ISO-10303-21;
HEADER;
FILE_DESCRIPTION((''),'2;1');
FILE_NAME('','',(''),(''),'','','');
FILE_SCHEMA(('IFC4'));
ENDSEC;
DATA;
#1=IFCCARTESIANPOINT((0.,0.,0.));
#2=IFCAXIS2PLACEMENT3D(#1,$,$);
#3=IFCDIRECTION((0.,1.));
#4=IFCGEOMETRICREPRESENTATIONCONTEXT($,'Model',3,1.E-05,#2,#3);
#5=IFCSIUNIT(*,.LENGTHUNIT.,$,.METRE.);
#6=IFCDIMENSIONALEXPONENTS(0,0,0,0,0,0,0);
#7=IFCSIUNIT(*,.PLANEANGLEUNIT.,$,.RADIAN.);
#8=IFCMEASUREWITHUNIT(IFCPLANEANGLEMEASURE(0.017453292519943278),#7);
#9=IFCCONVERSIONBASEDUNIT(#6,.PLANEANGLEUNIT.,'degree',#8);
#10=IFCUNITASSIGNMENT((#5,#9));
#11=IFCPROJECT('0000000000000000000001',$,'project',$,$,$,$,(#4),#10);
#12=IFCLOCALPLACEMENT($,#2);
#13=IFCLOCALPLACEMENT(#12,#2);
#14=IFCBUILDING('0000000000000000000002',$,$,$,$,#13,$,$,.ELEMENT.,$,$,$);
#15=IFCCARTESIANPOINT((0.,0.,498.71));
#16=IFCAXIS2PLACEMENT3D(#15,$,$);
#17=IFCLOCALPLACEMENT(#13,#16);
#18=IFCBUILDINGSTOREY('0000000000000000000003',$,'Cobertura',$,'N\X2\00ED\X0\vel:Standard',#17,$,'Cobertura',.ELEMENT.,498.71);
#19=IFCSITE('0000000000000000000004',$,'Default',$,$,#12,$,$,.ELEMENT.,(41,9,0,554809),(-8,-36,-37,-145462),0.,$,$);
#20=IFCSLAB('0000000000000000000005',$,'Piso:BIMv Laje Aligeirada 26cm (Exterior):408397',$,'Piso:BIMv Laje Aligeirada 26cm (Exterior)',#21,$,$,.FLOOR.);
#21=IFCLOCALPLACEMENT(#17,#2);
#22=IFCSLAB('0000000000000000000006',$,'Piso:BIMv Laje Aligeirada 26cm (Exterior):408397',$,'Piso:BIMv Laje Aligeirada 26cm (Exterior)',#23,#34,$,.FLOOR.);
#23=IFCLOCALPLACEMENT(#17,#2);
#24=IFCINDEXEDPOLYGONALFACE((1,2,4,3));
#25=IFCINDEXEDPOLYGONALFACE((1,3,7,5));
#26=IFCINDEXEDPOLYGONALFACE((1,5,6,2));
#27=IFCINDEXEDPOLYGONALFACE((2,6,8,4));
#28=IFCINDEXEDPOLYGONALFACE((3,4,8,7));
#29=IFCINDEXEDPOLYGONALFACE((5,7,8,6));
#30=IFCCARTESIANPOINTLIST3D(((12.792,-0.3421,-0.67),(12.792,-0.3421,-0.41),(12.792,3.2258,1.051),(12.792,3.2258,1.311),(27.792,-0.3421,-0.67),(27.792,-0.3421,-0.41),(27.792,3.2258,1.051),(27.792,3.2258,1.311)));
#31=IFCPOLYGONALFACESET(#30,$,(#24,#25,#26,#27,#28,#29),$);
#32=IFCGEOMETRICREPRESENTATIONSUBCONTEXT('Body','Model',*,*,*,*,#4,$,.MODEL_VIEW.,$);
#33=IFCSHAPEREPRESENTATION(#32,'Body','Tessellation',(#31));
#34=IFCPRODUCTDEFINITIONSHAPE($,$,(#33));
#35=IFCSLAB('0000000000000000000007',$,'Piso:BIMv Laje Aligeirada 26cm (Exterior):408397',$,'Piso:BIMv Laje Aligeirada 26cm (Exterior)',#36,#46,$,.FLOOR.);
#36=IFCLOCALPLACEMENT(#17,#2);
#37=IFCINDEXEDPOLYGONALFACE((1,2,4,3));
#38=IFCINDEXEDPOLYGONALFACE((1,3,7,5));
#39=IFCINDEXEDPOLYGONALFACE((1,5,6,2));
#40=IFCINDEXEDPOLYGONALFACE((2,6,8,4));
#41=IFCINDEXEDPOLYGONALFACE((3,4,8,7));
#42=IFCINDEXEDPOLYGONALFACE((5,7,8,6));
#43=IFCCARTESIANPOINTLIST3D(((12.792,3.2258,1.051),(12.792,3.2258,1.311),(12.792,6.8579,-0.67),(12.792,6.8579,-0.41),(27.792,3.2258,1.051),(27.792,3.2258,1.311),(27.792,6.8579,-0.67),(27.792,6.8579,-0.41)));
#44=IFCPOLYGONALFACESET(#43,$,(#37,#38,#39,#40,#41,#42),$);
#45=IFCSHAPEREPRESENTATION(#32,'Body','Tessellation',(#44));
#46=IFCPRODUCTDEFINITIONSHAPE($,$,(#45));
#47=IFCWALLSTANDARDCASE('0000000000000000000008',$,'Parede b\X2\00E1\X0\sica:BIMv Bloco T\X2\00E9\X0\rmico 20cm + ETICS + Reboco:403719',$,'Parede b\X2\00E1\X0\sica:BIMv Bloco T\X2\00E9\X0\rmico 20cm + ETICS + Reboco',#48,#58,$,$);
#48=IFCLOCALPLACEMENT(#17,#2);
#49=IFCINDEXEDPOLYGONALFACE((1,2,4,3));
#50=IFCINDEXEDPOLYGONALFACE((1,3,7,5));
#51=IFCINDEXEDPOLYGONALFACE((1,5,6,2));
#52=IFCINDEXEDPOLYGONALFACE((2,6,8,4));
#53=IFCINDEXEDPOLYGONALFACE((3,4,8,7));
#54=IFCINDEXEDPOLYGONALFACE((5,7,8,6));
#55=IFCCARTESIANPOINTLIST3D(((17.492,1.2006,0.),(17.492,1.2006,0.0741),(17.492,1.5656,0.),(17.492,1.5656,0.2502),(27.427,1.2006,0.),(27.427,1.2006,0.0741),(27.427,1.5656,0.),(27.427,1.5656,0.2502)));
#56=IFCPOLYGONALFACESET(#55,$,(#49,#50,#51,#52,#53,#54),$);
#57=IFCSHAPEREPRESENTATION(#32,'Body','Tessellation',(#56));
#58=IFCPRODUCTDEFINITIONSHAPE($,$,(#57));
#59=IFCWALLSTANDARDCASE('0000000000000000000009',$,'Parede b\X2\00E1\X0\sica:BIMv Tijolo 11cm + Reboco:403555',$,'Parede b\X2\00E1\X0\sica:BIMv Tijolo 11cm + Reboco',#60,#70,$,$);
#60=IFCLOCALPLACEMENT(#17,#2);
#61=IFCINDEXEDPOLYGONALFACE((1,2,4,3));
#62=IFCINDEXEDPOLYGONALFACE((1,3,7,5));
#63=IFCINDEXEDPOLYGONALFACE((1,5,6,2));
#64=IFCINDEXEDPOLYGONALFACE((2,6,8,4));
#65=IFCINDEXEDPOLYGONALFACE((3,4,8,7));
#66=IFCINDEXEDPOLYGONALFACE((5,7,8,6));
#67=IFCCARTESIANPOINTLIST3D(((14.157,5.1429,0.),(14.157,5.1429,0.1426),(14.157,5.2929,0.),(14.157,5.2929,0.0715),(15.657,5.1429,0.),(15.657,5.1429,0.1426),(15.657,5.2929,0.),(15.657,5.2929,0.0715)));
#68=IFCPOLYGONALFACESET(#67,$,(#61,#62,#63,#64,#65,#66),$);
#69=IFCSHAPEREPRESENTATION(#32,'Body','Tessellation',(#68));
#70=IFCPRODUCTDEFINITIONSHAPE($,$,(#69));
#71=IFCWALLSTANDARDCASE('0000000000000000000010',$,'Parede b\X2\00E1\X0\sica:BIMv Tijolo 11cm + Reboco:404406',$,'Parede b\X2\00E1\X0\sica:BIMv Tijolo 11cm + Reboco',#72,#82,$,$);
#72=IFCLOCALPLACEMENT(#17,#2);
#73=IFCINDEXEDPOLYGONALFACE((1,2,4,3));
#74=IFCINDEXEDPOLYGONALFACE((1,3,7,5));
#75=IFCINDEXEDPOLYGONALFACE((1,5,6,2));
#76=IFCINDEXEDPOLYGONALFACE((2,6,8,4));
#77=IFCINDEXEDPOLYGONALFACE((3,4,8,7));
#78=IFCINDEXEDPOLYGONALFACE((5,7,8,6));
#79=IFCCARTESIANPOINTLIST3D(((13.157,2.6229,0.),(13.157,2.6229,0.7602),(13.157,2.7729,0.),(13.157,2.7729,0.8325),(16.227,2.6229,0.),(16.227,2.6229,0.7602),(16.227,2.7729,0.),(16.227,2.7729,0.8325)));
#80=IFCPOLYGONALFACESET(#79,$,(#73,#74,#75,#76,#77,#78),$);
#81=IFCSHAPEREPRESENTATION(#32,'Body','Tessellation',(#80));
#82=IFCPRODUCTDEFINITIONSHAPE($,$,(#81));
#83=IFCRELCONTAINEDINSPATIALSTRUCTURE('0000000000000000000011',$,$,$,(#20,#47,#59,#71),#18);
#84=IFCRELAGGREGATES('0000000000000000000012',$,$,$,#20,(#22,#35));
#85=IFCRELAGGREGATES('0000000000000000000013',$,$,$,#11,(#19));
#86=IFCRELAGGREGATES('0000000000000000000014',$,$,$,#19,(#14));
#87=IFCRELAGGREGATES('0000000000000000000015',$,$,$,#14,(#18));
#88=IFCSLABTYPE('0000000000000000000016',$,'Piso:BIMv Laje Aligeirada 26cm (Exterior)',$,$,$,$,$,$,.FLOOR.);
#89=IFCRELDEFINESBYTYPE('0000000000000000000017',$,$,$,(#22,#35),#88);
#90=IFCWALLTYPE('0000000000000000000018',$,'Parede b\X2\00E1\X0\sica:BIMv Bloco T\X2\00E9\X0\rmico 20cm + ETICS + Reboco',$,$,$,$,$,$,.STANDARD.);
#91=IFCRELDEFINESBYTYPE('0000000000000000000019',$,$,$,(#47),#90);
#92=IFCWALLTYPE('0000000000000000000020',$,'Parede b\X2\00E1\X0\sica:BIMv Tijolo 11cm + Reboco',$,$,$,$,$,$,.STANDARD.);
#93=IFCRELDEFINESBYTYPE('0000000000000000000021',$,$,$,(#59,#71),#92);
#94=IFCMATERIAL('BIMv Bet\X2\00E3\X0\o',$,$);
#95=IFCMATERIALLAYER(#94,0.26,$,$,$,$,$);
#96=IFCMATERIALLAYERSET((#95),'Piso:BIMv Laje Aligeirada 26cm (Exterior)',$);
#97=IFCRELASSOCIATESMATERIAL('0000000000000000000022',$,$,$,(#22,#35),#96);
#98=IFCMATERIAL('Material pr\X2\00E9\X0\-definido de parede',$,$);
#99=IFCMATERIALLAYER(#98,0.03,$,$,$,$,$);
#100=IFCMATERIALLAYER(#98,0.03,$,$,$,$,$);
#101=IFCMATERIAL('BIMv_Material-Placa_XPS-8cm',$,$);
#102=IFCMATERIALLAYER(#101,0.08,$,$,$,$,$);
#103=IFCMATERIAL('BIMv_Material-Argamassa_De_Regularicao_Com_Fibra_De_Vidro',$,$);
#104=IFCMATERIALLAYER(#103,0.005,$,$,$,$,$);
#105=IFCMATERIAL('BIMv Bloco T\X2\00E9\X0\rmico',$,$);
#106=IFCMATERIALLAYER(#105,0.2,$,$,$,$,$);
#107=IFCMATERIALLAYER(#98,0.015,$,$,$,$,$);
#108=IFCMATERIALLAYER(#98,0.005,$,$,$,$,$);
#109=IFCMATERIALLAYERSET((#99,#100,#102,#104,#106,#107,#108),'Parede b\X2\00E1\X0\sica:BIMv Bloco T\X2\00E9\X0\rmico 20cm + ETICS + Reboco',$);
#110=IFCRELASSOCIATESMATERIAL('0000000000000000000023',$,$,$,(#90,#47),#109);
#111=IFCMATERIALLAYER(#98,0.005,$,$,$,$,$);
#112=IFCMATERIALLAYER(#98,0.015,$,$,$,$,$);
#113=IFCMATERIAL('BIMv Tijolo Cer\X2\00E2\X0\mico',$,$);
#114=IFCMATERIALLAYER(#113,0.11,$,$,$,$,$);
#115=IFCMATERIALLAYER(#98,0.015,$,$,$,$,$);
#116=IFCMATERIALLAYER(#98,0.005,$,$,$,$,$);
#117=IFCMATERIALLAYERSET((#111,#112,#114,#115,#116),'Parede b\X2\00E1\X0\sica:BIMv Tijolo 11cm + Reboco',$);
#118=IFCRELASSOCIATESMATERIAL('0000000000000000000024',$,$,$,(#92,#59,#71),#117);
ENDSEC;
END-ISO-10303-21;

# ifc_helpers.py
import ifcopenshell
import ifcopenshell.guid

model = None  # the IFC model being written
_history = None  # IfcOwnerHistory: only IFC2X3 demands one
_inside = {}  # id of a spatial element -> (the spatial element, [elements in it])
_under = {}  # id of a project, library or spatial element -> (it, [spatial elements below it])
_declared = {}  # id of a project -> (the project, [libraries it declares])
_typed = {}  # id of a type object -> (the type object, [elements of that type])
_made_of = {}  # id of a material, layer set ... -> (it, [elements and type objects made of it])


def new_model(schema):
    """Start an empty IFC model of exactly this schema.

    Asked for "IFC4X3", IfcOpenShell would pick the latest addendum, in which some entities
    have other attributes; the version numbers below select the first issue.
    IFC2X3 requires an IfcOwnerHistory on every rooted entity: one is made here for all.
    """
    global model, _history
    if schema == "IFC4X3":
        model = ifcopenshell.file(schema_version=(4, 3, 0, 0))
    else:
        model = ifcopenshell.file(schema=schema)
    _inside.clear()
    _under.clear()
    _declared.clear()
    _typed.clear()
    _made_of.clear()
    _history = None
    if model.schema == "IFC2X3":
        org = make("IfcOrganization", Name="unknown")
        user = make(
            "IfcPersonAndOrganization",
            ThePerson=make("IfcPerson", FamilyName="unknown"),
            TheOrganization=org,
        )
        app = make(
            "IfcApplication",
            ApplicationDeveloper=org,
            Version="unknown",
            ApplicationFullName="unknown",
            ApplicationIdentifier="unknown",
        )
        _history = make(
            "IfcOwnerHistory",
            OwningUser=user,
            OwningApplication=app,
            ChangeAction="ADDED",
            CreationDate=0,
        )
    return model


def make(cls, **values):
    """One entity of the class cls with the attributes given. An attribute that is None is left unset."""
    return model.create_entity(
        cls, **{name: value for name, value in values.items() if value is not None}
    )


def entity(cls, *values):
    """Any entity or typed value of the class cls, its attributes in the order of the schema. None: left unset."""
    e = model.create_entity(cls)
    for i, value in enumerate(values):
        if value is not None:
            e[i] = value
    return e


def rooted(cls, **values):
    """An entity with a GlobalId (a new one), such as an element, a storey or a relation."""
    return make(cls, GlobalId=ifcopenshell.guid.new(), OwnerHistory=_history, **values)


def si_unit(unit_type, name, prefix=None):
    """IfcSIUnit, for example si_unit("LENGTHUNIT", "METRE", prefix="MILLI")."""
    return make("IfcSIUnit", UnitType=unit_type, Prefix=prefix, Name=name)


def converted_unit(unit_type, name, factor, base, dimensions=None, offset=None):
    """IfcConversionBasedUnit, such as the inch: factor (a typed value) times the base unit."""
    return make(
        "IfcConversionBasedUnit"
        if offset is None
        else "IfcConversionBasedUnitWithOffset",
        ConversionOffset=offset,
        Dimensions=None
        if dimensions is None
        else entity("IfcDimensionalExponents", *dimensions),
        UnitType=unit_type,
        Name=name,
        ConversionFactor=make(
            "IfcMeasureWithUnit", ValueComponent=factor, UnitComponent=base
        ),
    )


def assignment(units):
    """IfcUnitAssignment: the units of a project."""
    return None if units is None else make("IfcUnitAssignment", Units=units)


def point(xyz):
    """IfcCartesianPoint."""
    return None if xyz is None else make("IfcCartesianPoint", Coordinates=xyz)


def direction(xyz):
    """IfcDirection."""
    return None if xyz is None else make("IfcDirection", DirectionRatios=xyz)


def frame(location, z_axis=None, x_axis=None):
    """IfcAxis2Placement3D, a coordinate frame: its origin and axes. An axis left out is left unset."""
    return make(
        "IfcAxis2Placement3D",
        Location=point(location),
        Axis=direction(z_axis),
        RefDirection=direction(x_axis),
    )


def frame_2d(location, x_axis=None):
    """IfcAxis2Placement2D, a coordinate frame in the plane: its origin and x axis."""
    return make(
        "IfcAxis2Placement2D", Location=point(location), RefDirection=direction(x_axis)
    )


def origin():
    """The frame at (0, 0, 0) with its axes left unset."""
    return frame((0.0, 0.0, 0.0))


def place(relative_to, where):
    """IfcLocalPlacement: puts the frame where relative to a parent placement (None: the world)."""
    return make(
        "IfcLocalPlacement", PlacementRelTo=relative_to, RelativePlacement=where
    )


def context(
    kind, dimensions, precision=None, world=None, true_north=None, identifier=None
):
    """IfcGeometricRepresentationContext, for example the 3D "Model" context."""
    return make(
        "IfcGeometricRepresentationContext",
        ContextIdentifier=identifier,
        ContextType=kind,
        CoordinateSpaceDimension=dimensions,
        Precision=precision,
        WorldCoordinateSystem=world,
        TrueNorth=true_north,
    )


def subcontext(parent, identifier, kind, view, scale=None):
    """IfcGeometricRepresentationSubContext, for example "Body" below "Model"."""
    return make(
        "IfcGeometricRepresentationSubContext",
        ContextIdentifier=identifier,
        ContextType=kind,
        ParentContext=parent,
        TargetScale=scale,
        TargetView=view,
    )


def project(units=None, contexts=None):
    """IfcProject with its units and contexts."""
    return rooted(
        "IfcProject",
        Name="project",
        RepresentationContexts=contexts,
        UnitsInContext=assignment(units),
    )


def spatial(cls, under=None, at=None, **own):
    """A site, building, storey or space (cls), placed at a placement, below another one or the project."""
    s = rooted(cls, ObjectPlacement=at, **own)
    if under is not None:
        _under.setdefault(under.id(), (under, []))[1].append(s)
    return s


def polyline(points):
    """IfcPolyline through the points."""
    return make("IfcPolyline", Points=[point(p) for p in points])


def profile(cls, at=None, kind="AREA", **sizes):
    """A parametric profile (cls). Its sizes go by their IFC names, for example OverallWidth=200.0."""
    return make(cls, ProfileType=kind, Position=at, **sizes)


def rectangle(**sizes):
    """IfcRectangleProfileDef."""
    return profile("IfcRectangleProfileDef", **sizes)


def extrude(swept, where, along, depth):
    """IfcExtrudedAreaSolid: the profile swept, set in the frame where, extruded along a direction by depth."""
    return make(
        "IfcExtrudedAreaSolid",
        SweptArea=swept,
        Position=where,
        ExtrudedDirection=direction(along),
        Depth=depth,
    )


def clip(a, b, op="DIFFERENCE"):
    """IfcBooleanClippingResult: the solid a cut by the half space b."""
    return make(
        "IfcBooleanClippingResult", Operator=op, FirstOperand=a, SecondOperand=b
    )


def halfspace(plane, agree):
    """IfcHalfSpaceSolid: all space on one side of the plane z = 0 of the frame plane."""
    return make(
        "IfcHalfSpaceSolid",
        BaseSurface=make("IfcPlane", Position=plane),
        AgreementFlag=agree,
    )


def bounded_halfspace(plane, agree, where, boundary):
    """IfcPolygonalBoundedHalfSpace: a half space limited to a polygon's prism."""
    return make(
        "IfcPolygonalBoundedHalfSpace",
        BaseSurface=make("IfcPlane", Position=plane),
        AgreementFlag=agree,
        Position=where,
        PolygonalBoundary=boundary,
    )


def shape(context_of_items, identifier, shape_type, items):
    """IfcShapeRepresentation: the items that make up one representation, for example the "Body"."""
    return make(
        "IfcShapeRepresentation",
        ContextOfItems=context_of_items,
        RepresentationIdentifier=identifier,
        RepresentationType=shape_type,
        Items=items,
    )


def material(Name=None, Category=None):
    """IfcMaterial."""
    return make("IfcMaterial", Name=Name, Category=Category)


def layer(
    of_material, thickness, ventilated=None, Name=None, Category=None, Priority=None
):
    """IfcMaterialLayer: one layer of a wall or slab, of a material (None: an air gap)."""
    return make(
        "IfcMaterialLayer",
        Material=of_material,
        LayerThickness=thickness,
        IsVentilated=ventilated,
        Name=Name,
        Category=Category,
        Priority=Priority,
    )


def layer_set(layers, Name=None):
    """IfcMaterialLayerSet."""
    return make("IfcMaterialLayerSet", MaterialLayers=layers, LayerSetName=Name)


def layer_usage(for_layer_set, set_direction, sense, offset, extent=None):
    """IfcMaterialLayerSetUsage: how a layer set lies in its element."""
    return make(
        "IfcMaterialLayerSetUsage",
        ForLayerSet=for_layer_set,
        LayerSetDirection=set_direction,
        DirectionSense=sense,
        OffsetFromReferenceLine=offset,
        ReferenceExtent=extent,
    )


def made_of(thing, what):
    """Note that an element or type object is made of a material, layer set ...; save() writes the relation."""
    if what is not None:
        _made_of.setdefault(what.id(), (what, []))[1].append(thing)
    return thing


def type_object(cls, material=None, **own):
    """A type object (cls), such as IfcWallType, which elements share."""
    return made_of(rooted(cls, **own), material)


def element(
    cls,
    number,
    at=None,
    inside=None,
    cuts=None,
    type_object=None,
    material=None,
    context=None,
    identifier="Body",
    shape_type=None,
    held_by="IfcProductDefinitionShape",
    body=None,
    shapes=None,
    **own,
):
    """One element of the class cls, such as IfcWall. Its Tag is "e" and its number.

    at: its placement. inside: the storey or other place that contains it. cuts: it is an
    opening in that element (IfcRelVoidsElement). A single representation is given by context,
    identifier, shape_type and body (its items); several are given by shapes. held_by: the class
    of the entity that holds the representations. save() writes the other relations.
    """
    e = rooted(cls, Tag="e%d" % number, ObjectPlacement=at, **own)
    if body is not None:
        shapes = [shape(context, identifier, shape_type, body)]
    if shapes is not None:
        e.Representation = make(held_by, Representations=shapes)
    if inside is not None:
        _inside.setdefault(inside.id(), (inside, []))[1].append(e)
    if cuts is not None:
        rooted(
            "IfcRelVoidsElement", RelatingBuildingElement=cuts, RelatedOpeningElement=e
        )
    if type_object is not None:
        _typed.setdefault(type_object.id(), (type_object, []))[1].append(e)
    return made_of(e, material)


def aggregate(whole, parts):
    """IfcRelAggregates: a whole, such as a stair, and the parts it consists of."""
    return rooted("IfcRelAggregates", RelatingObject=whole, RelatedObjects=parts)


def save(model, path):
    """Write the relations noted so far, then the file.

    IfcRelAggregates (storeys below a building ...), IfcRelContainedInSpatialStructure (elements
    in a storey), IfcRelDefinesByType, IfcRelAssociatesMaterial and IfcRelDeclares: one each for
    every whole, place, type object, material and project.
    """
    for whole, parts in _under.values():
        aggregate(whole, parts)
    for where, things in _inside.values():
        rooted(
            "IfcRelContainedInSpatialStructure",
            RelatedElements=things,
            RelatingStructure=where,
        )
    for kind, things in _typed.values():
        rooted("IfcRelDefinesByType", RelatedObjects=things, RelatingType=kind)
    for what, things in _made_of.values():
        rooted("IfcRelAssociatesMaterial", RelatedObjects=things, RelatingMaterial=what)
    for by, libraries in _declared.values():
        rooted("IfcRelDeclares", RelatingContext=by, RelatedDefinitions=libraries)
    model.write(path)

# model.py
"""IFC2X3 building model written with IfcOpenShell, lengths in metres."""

from ifc_helpers import new_model, entity, si_unit, converted_unit, direction, frame, frame_2d, origin, place, context, subcontext, project, spatial, polyline, rectangle, extrude, clip, halfspace, bounded_halfspace, material, layer, layer_set, layer_usage, type_object, element, aggregate, save


model = new_model("IFC2X3")

# Units and contexts
model_context = context("Model", 3, precision=1e-05, world=origin(), true_north=direction((0.0, 1.0)))
body_context = subcontext(model_context, "Body", "Model", "MODEL_VIEW")
ifc_project = project(units=[si_unit("LENGTHUNIT", "METRE"), converted_unit("PLANEANGLEUNIT", "degree", entity("IfcPlaneAngleMeasure", 0.017453292519943278), si_unit("PLANEANGLEUNIT", "RADIAN"), dimensions=[0, 0, 0, 0, 0, 0, 0])], contexts=[model_context])

# Site, building, storey
site_placement = place(None, origin())
site = spatial("IfcSite", under=ifc_project, at=site_placement, Name="Default", CompositionType="ELEMENT", RefLatitude=(41, 9, 0, 554809), RefLongitude=(-8, -36, -37, -145462), RefElevation=0.0)
building_placement = place(site_placement, origin())
building = spatial("IfcBuilding", under=site, at=building_placement, CompositionType="ELEMENT")
storey_placement = place(building_placement, frame((0.0, 0.0, 498.71)))
storey = spatial("IfcBuildingStorey", under=building, at=storey_placement, Name="Cobertura", ObjectType="Nível:Standard", LongName="Cobertura", CompositionType="ELEMENT", Elevation=498.71)

# Slabs
slab_1_placement = place(storey_placement, frame((12.792, -0.3421, -0.67)))
slab_1 = element("IfcSlab", 1, at=slab_1_placement, inside=storey, Name="Piso:BIMv Laje Aligeirada 26cm (Exterior):408397", ObjectType="Piso:BIMv Laje Aligeirada 26cm (Exterior)", PredefinedType="FLOOR")
ifc_material_1 = material(Name="BIMv Betão")
ifc_layer_1 = layer(ifc_material_1, 0.26)
ifc_layer_set_1 = layer_set([ifc_layer_1], Name="Piso:BIMv Laje Aligeirada 26cm (Exterior)")
slab_type = type_object("IfcSlabType", Name="Piso:BIMv Laje Aligeirada 26cm (Exterior)", PredefinedType="FLOOR")
slab_2_placement = place(slab_1_placement, origin())
slab_2 = element("IfcSlab", 2, at=slab_2_placement, type_object=slab_type, material=ifc_layer_set_1, Name="Piso:BIMv Laje Aligeirada 26cm (Exterior):408397", ObjectType="Piso:BIMv Laje Aligeirada 26cm (Exterior)", PredefinedType="FLOOR", context=body_context, shape_type="SweptSolid", body=[
    extrude(rectangle(XDim=15.0, YDim=3.9613, at=frame_2d((0.0, 0.0), x_axis=(-1.0, 0.0))), frame((7.5, 1.784, 1.1205), z_axis=(0.0, -0.43445, 0.900696), x_axis=(1.0, 0.0, 0.0)), (0.0, -0.43445, -0.900696), 0.26),
])
slab_3_placement = place(slab_1_placement, origin())
slab_3 = element("IfcSlab", 3, at=slab_3_placement, type_object=slab_type, material=ifc_layer_set_1, Name="Piso:BIMv Laje Aligeirada 26cm (Exterior):408397", ObjectType="Piso:BIMv Laje Aligeirada 26cm (Exterior)", PredefinedType="FLOOR", context=body_context, shape_type="SweptSolid", body=[
    extrude(rectangle(XDim=4.0192, YDim=15.0, at=frame_2d((0.0, 0.0), x_axis=(0.0, -1.0))), frame((7.5, 5.384, 1.1205), z_axis=(0.0, 0.42819, 0.903689), x_axis=(1.0, 0.0, 0.0)), (0.0, 0.42819, -0.903689), 0.26),
])
aggregate(slab_1, [slab_2, slab_3])

# Walls
ifc_material_2 = material(Name="Material pré-definido de parede")
ifc_layer_2 = layer(ifc_material_2, 0.03)
ifc_layer_3 = layer(ifc_material_2, 0.03)
ifc_material_3 = material(Name="BIMv_Material-Placa_XPS-8cm")
ifc_layer_4 = layer(ifc_material_3, 0.08)
ifc_material_4 = material(Name="BIMv_Material-Argamassa_De_Regularicao_Com_Fibra_De_Vidro")
ifc_layer_5 = layer(ifc_material_4, 0.005)
ifc_material_5 = material(Name="BIMv Bloco Térmico")
ifc_layer_6 = layer(ifc_material_5, 0.2)
ifc_layer_7 = layer(ifc_material_2, 0.015)
ifc_layer_8 = layer(ifc_material_2, 0.005)
ifc_layer_set_2 = layer_set([ifc_layer_2, ifc_layer_3, ifc_layer_4, ifc_layer_5, ifc_layer_6, ifc_layer_7, ifc_layer_8], Name="Parede básica:BIMv Bloco Térmico 20cm + ETICS + Reboco")
wall_type_1 = type_object("IfcWallType", Name="Parede básica:BIMv Bloco Térmico 20cm + ETICS + Reboco", PredefinedType="STANDARD", material=ifc_layer_set_2)
ifc_layer_usage_1 = layer_usage(ifc_layer_set_2, "AXIS2", "POSITIVE", -0.1825)
wall_1_placement = place(storey_placement, frame((17.492, 1.3831, 0.0)))
element("IfcWallStandardCase", 4, at=wall_1_placement, inside=storey, type_object=wall_type_1, material=ifc_layer_usage_1, Name="Parede básica:BIMv Bloco Térmico 20cm + ETICS + Reboco:403719", ObjectType="Parede básica:BIMv Bloco Térmico 20cm + ETICS + Reboco", context=body_context, shape_type="Clipping", body=[
    clip(clip(extrude(rectangle(XDim=9.935, YDim=0.365, at=frame_2d((4.9675, 0.0), x_axis=(1.0, 0.0))), origin(), (0.0, 0.0, 1.0), 0.2502), bounded_halfspace(frame((0.0, -0.1825, 0.0741), z_axis=(0.0, -0.43445, 0.900696), x_axis=(0.0, 0.900696, 0.43445)), False, frame((0.0, -0.1825, 0.0741)), polyline([(0.0, 0.0), (9.935, 0.0), (9.935, 0.365), (6.935, 0.365), (6.785, 0.365), (5.285, 0.365), (5.135, 0.365), (3.635, 0.365), (3.485, 0.365), (0.385, 0.365), (0.235, 0.365), (0.0, 0.365), (0.0, 0.0)]))), halfspace(frame((0.0, 0.0, -2.88)), True)),
])
ifc_layer_9 = layer(ifc_material_2, 0.005)
ifc_layer_10 = layer(ifc_material_2, 0.015)
ifc_material_6 = material(Name="BIMv Tijolo Cerâmico")
ifc_layer_11 = layer(ifc_material_6, 0.11)
ifc_layer_12 = layer(ifc_material_2, 0.015)
ifc_layer_13 = layer(ifc_material_2, 0.005)
ifc_layer_set_3 = layer_set([ifc_layer_9, ifc_layer_10, ifc_layer_11, ifc_layer_12, ifc_layer_13], Name="Parede básica:BIMv Tijolo 11cm + Reboco")
ifc_layer_usage_2 = layer_usage(ifc_layer_set_3, "AXIS2", "NEGATIVE", 0.075)
wall_type_2 = type_object("IfcWallType", Name="Parede básica:BIMv Tijolo 11cm + Reboco", PredefinedType="STANDARD", material=ifc_layer_set_3)
wall_2_placement = place(storey_placement, frame((14.157, 5.2179, 0.0)))
element("IfcWallStandardCase", 5, at=wall_2_placement, inside=storey, type_object=wall_type_2, material=ifc_layer_usage_2, Name="Parede básica:BIMv Tijolo 11cm + Reboco:403555", ObjectType="Parede básica:BIMv Tijolo 11cm + Reboco", context=body_context, shape_type="Clipping", body=[
    clip(clip(extrude(rectangle(XDim=1.5, YDim=0.15, at=frame_2d((0.75, 0.0), x_axis=(1.0, 0.0))), origin(), (0.0, 0.0, 1.0), 0.1426), bounded_halfspace(frame((0.0, -0.075, 0.1426), z_axis=(0.0, 0.42819, 0.903689), x_axis=(-1.0, 0.0, 0.0)), False, frame((0.0, -0.075, 0.1426)), polyline([(0.0, 0.0), (0.15, 0.0), (1.5, 0.0), (1.5, 0.15), (0.0, 0.15), (0.0, 0.0)]))), halfspace(frame((0.0, 0.0, -2.88)), True)),
])
ifc_layer_usage_3 = layer_usage(ifc_layer_set_3, "AXIS2", "POSITIVE", -0.075)
wall_3_placement = place(storey_placement, frame((16.227, 2.6979, 0.0), z_axis=(0.0, 0.0, 1.0), x_axis=(-1.0, 0.0, 0.0)))
element("IfcWallStandardCase", 6, at=wall_3_placement, inside=storey, type_object=wall_type_2, material=ifc_layer_usage_3, Name="Parede básica:BIMv Tijolo 11cm + Reboco:404406", ObjectType="Parede básica:BIMv Tijolo 11cm + Reboco", context=body_context, shape_type="Clipping", body=[
    clip(clip(extrude(rectangle(XDim=3.07, YDim=0.15, at=frame_2d((1.535, 0.0), x_axis=(1.0, 0.0))), origin(), (0.0, 0.0, 1.0), 0.8325), bounded_halfspace(frame((0.0, -0.075, 0.8325), z_axis=(0.0, 0.43445, 0.900696), x_axis=(0.0, -0.900696, 0.43445)), False, frame((0.0, -0.075, 0.8325)), polyline([(0.0, 0.0), (0.15, 0.0), (1.92, 0.0), (2.07, 0.0), (3.07, 0.0), (3.07, 0.15), (0.0, 0.15), (0.0, 0.0)]))), halfspace(frame((0.0, 0.0, -2.88)), True)),
])

save(model, "model.ifc")
